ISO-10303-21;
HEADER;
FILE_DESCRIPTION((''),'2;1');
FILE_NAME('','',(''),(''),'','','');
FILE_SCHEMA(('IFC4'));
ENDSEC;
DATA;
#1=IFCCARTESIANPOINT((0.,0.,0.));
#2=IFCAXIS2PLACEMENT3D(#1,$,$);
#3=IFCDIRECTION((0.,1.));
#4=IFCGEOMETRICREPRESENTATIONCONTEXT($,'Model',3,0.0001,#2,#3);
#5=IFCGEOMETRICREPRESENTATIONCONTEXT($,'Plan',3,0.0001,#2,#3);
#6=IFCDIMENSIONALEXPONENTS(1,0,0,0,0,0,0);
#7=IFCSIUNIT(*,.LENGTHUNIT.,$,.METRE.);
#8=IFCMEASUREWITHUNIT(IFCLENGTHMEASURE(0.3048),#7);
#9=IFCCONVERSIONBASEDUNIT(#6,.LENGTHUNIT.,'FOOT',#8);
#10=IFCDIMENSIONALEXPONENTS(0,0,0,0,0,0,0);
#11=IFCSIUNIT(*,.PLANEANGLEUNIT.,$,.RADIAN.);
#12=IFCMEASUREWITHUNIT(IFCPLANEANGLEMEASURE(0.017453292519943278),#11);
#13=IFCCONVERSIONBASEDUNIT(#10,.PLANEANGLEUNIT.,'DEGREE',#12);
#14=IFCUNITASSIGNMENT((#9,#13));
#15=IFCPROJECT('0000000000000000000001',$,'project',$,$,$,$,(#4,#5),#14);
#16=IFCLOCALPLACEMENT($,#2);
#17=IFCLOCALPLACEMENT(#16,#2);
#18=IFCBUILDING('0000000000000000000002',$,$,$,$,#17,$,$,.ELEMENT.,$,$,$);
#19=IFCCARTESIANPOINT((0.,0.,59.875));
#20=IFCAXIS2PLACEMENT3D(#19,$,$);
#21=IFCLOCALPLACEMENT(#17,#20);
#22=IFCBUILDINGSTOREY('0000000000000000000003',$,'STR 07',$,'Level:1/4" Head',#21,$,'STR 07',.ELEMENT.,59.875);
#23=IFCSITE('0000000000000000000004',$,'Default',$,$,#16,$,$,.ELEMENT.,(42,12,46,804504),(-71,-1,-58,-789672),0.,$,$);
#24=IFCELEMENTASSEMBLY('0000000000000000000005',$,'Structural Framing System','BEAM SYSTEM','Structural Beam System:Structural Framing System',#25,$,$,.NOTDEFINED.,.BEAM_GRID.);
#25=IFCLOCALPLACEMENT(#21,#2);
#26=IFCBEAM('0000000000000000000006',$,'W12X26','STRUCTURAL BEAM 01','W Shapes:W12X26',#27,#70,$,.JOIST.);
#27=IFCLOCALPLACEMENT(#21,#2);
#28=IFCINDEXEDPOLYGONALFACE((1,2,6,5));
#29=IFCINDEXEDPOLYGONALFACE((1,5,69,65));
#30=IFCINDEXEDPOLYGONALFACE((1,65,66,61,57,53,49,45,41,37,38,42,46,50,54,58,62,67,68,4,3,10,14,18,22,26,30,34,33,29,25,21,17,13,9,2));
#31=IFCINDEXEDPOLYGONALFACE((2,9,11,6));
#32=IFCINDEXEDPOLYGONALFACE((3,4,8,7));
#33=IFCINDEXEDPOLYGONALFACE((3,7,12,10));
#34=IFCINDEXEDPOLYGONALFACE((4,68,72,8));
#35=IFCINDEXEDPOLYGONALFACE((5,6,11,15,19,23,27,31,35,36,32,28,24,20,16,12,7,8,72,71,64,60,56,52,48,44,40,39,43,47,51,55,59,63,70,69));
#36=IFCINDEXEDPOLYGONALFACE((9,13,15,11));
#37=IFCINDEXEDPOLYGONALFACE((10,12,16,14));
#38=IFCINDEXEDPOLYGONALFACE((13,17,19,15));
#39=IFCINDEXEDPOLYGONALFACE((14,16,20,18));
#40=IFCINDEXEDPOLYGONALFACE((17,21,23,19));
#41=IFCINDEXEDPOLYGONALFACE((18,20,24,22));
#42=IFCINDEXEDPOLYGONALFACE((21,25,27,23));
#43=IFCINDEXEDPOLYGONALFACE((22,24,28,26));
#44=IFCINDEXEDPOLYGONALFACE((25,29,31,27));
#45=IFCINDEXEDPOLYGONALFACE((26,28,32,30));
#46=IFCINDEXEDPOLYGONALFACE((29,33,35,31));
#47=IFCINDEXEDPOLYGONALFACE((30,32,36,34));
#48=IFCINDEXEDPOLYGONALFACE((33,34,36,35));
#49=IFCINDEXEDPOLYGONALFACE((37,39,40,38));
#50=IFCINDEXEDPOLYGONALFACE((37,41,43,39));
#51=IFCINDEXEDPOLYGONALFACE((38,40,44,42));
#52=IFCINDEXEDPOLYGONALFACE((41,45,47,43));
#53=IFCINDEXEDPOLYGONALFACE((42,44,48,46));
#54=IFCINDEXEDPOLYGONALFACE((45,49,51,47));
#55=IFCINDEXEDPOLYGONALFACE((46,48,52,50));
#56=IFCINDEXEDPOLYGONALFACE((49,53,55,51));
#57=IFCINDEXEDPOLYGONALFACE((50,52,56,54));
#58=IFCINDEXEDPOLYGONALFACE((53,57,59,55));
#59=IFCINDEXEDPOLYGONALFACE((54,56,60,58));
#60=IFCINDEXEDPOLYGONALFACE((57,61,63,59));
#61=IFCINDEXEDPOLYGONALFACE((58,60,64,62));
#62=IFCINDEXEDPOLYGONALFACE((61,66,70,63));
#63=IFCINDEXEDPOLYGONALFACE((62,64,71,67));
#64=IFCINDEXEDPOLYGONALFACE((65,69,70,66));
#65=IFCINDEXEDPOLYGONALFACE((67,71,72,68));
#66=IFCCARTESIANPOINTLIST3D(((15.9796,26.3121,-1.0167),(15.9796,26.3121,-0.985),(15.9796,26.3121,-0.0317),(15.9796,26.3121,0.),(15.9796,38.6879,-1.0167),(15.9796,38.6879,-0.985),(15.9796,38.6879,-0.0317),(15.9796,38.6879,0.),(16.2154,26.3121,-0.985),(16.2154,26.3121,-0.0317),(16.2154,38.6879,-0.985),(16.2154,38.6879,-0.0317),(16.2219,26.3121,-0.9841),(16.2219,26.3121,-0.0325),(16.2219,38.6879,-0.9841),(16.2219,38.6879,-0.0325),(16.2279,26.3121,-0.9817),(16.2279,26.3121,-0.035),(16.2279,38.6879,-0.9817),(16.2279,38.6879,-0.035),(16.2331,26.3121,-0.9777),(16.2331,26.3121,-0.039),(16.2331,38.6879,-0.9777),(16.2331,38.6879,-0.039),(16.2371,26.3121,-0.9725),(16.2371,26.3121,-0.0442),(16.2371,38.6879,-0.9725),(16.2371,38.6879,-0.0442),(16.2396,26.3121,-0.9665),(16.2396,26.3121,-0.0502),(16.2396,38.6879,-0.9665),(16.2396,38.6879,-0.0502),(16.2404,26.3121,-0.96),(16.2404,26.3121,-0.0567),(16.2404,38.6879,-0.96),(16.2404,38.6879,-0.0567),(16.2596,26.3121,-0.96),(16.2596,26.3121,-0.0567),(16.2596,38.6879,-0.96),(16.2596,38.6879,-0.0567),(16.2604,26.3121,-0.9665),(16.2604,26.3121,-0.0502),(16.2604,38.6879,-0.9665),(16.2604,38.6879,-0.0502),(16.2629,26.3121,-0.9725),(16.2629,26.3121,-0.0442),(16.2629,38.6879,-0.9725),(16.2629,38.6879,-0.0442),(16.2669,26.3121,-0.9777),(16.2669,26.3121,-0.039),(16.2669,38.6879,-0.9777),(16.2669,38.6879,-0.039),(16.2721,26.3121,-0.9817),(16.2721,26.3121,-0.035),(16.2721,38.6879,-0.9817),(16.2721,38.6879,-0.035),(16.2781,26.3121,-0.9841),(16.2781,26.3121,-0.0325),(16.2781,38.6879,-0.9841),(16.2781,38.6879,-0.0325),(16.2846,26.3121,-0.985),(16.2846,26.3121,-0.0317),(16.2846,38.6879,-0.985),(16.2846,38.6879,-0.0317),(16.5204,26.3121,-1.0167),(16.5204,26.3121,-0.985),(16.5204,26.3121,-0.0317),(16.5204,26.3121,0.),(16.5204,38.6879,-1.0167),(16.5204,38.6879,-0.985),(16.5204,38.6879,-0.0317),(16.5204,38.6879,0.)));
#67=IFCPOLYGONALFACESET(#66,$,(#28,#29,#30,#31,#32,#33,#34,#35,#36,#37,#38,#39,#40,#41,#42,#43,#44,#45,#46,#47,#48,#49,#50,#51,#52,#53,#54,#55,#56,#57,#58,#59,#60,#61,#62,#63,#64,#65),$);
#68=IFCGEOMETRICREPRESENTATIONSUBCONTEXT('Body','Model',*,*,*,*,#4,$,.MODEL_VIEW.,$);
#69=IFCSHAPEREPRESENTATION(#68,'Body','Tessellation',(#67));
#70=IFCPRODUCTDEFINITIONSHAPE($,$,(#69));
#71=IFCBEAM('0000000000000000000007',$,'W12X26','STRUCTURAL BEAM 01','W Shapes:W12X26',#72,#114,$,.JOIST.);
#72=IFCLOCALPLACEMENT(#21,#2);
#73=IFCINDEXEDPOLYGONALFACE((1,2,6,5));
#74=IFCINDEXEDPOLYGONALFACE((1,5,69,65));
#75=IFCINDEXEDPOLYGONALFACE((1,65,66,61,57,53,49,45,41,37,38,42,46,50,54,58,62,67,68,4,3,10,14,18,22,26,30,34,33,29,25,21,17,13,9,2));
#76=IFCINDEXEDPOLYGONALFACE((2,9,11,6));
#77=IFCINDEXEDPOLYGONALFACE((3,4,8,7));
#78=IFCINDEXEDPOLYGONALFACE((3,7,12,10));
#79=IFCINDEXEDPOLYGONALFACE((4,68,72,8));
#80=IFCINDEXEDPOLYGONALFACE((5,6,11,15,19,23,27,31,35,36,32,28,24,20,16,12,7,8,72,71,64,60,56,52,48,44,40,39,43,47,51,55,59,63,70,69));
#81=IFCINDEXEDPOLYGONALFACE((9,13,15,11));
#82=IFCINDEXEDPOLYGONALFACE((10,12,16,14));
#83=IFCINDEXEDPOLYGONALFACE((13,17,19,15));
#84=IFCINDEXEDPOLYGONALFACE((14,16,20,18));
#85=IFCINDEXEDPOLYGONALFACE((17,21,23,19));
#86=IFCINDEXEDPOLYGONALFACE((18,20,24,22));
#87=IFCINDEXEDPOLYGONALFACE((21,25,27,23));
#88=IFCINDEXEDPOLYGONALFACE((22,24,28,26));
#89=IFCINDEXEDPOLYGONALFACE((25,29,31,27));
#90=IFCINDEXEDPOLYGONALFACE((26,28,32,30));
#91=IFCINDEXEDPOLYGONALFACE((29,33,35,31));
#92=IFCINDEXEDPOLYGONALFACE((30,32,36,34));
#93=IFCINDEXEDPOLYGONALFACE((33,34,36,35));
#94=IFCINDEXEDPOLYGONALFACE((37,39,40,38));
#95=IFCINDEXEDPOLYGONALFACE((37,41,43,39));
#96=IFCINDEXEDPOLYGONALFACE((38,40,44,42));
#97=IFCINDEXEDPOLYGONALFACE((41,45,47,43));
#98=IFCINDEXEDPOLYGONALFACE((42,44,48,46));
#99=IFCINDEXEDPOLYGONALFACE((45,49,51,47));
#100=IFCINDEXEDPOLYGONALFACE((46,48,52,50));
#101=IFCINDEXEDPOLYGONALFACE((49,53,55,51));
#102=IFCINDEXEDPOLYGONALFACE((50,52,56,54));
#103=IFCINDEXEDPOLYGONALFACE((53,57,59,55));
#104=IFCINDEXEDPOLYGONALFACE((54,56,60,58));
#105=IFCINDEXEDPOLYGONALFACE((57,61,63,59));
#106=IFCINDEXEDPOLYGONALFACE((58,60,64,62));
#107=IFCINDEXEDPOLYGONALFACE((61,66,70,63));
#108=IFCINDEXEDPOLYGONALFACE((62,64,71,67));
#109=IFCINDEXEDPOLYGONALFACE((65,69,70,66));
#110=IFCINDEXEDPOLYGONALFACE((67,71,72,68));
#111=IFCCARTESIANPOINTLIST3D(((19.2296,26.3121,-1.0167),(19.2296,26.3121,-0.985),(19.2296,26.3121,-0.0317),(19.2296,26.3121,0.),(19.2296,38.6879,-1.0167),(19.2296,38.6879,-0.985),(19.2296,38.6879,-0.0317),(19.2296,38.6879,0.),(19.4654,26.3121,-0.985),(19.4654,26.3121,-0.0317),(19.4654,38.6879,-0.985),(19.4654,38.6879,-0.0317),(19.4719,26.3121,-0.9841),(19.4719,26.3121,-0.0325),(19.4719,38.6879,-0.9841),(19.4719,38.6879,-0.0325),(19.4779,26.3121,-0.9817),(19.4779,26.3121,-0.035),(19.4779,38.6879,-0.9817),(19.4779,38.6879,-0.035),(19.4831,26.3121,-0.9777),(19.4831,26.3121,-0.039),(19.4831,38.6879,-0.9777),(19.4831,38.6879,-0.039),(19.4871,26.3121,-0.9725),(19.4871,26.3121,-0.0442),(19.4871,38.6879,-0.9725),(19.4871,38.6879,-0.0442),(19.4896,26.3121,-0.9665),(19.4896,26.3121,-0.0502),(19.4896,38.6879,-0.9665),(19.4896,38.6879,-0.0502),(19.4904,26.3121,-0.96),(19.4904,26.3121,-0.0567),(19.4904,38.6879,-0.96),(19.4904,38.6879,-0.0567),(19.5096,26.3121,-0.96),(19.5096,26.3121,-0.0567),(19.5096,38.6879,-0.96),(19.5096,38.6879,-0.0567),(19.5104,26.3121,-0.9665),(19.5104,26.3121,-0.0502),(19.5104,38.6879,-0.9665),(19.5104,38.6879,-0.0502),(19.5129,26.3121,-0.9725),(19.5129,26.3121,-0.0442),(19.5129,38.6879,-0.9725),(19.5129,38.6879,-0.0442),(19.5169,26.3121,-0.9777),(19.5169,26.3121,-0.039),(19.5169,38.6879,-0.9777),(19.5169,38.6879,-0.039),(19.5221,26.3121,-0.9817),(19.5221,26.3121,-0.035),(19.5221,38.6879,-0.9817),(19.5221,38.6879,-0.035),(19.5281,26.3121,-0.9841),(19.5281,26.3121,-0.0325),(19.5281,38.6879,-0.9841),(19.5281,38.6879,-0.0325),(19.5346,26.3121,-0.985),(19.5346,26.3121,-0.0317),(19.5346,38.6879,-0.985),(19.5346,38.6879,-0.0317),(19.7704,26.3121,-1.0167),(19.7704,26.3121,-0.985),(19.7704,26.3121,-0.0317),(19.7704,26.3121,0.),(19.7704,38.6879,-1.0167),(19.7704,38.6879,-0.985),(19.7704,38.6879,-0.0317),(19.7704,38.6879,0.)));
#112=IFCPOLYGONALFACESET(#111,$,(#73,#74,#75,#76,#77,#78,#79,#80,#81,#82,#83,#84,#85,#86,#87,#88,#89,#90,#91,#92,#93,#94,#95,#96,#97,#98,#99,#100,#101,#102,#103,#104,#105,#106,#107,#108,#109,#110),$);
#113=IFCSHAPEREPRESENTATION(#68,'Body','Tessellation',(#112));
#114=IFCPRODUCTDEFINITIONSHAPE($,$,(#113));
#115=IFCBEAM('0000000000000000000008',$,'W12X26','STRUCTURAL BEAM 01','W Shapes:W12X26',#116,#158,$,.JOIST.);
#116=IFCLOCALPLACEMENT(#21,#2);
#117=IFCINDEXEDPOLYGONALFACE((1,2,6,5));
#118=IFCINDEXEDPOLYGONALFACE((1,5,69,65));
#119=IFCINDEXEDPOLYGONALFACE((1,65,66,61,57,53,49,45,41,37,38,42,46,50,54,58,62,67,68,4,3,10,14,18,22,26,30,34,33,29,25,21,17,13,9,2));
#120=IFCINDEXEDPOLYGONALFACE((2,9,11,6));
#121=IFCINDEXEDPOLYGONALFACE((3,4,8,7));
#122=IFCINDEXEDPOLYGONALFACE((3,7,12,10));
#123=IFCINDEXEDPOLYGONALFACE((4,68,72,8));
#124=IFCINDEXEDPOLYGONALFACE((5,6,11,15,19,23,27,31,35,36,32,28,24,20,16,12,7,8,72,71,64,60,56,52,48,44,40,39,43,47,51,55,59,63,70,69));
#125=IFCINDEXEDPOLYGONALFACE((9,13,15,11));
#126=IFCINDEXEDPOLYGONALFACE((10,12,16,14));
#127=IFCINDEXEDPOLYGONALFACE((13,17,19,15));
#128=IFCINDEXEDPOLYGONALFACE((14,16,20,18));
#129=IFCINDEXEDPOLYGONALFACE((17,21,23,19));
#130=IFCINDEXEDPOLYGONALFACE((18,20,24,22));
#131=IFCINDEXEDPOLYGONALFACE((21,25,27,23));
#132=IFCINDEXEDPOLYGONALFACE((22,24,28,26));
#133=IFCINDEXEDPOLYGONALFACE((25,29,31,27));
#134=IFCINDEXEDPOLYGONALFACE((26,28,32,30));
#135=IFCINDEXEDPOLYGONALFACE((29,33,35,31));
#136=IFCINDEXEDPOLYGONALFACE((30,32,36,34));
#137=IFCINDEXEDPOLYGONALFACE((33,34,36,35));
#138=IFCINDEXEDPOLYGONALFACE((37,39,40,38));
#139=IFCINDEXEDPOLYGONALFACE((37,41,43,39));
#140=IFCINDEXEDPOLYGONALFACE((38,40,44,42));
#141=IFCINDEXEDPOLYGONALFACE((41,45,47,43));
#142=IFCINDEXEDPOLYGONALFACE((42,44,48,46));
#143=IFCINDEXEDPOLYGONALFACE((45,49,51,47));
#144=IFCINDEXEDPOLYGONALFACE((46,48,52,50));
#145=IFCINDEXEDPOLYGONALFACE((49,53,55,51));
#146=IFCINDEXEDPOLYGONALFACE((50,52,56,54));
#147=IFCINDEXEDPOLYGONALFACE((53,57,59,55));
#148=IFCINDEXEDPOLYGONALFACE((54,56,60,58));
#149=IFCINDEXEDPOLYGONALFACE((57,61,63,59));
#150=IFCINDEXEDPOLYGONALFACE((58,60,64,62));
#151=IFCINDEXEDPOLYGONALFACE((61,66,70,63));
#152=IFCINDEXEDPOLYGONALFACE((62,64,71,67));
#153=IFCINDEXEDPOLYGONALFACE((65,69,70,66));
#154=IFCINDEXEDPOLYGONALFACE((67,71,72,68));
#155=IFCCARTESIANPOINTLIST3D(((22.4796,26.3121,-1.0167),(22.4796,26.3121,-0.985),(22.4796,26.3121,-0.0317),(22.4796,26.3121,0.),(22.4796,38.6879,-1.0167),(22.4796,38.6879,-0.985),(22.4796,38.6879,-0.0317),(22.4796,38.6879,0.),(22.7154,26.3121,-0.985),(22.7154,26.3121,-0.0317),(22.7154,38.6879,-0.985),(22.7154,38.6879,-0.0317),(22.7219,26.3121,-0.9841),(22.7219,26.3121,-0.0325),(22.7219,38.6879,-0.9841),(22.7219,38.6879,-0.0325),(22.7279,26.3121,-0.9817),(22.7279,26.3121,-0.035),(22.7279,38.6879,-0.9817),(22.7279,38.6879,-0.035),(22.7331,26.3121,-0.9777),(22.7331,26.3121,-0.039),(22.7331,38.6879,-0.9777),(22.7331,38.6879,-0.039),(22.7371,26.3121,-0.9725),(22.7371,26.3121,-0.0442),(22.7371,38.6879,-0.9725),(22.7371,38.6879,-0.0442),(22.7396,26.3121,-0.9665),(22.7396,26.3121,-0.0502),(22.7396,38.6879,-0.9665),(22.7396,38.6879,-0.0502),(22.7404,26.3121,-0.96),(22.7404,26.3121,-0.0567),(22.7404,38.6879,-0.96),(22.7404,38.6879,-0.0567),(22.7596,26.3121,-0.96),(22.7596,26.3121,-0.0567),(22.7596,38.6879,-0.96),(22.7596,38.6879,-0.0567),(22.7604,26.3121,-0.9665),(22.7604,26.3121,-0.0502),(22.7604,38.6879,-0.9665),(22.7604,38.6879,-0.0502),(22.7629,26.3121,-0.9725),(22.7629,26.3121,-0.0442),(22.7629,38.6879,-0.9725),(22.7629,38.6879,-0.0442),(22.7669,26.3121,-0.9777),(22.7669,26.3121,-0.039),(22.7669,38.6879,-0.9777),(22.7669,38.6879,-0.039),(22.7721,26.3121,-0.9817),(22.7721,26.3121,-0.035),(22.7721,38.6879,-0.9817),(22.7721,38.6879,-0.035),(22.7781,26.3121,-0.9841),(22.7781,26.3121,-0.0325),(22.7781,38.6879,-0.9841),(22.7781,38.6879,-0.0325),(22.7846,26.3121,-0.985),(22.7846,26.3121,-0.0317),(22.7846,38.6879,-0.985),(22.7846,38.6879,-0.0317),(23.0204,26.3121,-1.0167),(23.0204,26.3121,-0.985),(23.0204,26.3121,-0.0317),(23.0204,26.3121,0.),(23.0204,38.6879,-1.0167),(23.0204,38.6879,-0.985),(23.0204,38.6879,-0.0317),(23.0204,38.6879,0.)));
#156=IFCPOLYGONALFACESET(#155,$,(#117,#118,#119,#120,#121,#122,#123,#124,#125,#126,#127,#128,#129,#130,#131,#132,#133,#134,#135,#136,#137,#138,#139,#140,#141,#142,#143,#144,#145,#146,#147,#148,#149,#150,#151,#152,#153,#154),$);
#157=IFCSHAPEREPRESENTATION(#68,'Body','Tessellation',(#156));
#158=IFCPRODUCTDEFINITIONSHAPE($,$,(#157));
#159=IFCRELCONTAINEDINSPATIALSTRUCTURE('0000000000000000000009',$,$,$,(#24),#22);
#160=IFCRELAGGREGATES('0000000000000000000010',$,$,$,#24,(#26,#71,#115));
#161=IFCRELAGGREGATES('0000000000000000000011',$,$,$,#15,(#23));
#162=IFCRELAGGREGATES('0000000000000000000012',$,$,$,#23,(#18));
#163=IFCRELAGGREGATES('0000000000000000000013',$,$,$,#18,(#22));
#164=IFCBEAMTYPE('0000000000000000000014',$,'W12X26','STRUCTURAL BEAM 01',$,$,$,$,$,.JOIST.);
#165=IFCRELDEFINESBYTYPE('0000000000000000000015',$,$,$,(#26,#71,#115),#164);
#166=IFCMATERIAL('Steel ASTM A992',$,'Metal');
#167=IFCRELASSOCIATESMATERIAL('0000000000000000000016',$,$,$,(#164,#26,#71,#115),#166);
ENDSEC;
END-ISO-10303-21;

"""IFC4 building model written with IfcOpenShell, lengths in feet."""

from ifc_helpers import new_model, entity, si_unit, converted_unit, direction, frame, origin, place, context, subcontext, project, spatial, line, arc, indexed_curve, outline, extrude, source, transform, mapped, material, type_object, type_shapes, element, aggregate, save


model = new_model("IFC4")

# Units and contexts
model_context = context("Model", 3, precision=0.0001, world=origin(), true_north=direction((0.0, 1.0)))
plan_context = context("Plan", 3, precision=0.0001, world=origin(), true_north=direction((0.0, 1.0)))
body_context = subcontext(model_context, "Body", "Model", "MODEL_VIEW")
ifc_project = project(units=[converted_unit("LENGTHUNIT", "FOOT", entity("IfcLengthMeasure", 0.3048), si_unit("LENGTHUNIT", "METRE"), dimensions=[1, 0, 0, 0, 0, 0, 0]), converted_unit("PLANEANGLEUNIT", "DEGREE", entity("IfcPlaneAngleMeasure", 0.017453292519943278), si_unit("PLANEANGLEUNIT", "RADIAN"), dimensions=[0, 0, 0, 0, 0, 0, 0])], contexts=[model_context, plan_context])

# Site, building, storey
site_placement = place(None, origin())
site = spatial("IfcSite", under=ifc_project, at=site_placement, Name="Default", CompositionType="ELEMENT", RefLatitude=(42, 12, 46, 804504), RefLongitude=(-71, -1, -58, -789672), RefElevation=0.0)
building_placement = place(site_placement, origin())
building = spatial("IfcBuilding", under=site, at=building_placement, CompositionType="ELEMENT")
storey_placement = place(building_placement, frame((0.0, 0.0, 59.875)))
storey = spatial("IfcBuildingStorey", under=building, at=storey_placement, Name="STR 07", ObjectType="Level:1/4\" Head", LongName="STR 07", CompositionType="ELEMENT", Elevation=59.875)

# Element assembly, beams
ifc_material = material(Name="Steel ASTM A992", Category="Metal")
beam_type_1 = type_object("IfcBeamType", Name="W12X26", Description="STRUCTURAL BEAM 01", PredefinedType="JOIST", material=ifc_material)
shared_shape = source(origin(), body_context, "Body", "SweptSolid", [
    extrude(outline(indexed_curve([(-0.2704, -0.4767), (-0.2704, -0.5083), (0.2704, -0.5083), (0.2704, -0.4767), (0.0346, -0.4767), (0.0169, -0.4693), (0.0096, -0.4517), (0.0096, 0.4517), (0.0169, 0.4693), (0.0346, 0.4767), (0.2704, 0.4767), (0.2704, 0.5083), (-0.2704, 0.5083), (-0.2704, 0.4767), (-0.0346, 0.4767), (-0.0169, 0.4693), (-0.0096, 0.4517), (-0.0096, -0.4517), (-0.0169, -0.4693), (-0.0346, -0.4767)], segments=[line(1, 2, 3, 4, 5), arc(5, 6, 7), line(7, 8), arc(8, 9, 10), line(10, 11, 12, 13, 14, 15), arc(15, 16, 17), line(17, 18), arc(18, 19, 20), line(20, 1)], self_intersect=False)), frame((-6.1879, 0.0, 0.0), z_axis=(-1.0, 0.0, 0.0), x_axis=(0.0, -1.0, 0.0)), (0.0, 0.0, -1.0), 12.3758),
])
type_shapes(beam_type_1, [shared_shape])
assembly_1_placement = place(storey_placement, origin())
assembly_1 = element("IfcElementAssembly", 1, at=assembly_1_placement, inside=storey, Name="Structural Framing System", Description="BEAM SYSTEM", ObjectType="Structural Beam System:Structural Framing System", AssemblyPlace="NOTDEFINED", PredefinedType="BEAM_GRID")
beam_1_placement = place(assembly_1_placement, frame((16.25, 32.5, -0.5083), z_axis=(0.0, 0.0, 1.0), x_axis=(0.0, 1.0, 0.0)))
beam_1 = element("IfcBeam", 2, at=beam_1_placement, type_object=beam_type_1, material=ifc_material, Name="W12X26", Description="STRUCTURAL BEAM 01", ObjectType="W Shapes:W12X26", PredefinedType="JOIST", context=body_context, shape_type="MappedRepresentation", body=[
    mapped(shared_shape, transform((0.0, 0.0, 0.0), scale=1.0)),
])
beam_2_placement = place(assembly_1_placement, frame((19.5, 32.5, -0.5083), z_axis=(0.0, 0.0, 1.0), x_axis=(0.0, 1.0, 0.0)))
beam_2 = element("IfcBeam", 3, at=beam_2_placement, type_object=beam_type_1, material=ifc_material, Name="W12X26", Description="STRUCTURAL BEAM 01", ObjectType="W Shapes:W12X26", PredefinedType="JOIST", context=body_context, shape_type="MappedRepresentation", body=[
    mapped(shared_shape, transform((0.0, 0.0, 0.0), scale=1.0)),
])
beam_3_placement = place(assembly_1_placement, frame((22.75, 32.5, -0.5083), z_axis=(0.0, 0.0, 1.0), x_axis=(0.0, 1.0, 0.0)))
beam_3 = element("IfcBeam", 4, at=beam_3_placement, type_object=beam_type_1, material=ifc_material, Name="W12X26", Description="STRUCTURAL BEAM 01", ObjectType="W Shapes:W12X26", PredefinedType="JOIST", context=body_context, shape_type="MappedRepresentation", body=[
    mapped(shared_shape, transform((0.0, 0.0, 0.0), scale=1.0)),
])
aggregate(assembly_1, [beam_1, beam_2, beam_3])

save(model, "model.ifc")
